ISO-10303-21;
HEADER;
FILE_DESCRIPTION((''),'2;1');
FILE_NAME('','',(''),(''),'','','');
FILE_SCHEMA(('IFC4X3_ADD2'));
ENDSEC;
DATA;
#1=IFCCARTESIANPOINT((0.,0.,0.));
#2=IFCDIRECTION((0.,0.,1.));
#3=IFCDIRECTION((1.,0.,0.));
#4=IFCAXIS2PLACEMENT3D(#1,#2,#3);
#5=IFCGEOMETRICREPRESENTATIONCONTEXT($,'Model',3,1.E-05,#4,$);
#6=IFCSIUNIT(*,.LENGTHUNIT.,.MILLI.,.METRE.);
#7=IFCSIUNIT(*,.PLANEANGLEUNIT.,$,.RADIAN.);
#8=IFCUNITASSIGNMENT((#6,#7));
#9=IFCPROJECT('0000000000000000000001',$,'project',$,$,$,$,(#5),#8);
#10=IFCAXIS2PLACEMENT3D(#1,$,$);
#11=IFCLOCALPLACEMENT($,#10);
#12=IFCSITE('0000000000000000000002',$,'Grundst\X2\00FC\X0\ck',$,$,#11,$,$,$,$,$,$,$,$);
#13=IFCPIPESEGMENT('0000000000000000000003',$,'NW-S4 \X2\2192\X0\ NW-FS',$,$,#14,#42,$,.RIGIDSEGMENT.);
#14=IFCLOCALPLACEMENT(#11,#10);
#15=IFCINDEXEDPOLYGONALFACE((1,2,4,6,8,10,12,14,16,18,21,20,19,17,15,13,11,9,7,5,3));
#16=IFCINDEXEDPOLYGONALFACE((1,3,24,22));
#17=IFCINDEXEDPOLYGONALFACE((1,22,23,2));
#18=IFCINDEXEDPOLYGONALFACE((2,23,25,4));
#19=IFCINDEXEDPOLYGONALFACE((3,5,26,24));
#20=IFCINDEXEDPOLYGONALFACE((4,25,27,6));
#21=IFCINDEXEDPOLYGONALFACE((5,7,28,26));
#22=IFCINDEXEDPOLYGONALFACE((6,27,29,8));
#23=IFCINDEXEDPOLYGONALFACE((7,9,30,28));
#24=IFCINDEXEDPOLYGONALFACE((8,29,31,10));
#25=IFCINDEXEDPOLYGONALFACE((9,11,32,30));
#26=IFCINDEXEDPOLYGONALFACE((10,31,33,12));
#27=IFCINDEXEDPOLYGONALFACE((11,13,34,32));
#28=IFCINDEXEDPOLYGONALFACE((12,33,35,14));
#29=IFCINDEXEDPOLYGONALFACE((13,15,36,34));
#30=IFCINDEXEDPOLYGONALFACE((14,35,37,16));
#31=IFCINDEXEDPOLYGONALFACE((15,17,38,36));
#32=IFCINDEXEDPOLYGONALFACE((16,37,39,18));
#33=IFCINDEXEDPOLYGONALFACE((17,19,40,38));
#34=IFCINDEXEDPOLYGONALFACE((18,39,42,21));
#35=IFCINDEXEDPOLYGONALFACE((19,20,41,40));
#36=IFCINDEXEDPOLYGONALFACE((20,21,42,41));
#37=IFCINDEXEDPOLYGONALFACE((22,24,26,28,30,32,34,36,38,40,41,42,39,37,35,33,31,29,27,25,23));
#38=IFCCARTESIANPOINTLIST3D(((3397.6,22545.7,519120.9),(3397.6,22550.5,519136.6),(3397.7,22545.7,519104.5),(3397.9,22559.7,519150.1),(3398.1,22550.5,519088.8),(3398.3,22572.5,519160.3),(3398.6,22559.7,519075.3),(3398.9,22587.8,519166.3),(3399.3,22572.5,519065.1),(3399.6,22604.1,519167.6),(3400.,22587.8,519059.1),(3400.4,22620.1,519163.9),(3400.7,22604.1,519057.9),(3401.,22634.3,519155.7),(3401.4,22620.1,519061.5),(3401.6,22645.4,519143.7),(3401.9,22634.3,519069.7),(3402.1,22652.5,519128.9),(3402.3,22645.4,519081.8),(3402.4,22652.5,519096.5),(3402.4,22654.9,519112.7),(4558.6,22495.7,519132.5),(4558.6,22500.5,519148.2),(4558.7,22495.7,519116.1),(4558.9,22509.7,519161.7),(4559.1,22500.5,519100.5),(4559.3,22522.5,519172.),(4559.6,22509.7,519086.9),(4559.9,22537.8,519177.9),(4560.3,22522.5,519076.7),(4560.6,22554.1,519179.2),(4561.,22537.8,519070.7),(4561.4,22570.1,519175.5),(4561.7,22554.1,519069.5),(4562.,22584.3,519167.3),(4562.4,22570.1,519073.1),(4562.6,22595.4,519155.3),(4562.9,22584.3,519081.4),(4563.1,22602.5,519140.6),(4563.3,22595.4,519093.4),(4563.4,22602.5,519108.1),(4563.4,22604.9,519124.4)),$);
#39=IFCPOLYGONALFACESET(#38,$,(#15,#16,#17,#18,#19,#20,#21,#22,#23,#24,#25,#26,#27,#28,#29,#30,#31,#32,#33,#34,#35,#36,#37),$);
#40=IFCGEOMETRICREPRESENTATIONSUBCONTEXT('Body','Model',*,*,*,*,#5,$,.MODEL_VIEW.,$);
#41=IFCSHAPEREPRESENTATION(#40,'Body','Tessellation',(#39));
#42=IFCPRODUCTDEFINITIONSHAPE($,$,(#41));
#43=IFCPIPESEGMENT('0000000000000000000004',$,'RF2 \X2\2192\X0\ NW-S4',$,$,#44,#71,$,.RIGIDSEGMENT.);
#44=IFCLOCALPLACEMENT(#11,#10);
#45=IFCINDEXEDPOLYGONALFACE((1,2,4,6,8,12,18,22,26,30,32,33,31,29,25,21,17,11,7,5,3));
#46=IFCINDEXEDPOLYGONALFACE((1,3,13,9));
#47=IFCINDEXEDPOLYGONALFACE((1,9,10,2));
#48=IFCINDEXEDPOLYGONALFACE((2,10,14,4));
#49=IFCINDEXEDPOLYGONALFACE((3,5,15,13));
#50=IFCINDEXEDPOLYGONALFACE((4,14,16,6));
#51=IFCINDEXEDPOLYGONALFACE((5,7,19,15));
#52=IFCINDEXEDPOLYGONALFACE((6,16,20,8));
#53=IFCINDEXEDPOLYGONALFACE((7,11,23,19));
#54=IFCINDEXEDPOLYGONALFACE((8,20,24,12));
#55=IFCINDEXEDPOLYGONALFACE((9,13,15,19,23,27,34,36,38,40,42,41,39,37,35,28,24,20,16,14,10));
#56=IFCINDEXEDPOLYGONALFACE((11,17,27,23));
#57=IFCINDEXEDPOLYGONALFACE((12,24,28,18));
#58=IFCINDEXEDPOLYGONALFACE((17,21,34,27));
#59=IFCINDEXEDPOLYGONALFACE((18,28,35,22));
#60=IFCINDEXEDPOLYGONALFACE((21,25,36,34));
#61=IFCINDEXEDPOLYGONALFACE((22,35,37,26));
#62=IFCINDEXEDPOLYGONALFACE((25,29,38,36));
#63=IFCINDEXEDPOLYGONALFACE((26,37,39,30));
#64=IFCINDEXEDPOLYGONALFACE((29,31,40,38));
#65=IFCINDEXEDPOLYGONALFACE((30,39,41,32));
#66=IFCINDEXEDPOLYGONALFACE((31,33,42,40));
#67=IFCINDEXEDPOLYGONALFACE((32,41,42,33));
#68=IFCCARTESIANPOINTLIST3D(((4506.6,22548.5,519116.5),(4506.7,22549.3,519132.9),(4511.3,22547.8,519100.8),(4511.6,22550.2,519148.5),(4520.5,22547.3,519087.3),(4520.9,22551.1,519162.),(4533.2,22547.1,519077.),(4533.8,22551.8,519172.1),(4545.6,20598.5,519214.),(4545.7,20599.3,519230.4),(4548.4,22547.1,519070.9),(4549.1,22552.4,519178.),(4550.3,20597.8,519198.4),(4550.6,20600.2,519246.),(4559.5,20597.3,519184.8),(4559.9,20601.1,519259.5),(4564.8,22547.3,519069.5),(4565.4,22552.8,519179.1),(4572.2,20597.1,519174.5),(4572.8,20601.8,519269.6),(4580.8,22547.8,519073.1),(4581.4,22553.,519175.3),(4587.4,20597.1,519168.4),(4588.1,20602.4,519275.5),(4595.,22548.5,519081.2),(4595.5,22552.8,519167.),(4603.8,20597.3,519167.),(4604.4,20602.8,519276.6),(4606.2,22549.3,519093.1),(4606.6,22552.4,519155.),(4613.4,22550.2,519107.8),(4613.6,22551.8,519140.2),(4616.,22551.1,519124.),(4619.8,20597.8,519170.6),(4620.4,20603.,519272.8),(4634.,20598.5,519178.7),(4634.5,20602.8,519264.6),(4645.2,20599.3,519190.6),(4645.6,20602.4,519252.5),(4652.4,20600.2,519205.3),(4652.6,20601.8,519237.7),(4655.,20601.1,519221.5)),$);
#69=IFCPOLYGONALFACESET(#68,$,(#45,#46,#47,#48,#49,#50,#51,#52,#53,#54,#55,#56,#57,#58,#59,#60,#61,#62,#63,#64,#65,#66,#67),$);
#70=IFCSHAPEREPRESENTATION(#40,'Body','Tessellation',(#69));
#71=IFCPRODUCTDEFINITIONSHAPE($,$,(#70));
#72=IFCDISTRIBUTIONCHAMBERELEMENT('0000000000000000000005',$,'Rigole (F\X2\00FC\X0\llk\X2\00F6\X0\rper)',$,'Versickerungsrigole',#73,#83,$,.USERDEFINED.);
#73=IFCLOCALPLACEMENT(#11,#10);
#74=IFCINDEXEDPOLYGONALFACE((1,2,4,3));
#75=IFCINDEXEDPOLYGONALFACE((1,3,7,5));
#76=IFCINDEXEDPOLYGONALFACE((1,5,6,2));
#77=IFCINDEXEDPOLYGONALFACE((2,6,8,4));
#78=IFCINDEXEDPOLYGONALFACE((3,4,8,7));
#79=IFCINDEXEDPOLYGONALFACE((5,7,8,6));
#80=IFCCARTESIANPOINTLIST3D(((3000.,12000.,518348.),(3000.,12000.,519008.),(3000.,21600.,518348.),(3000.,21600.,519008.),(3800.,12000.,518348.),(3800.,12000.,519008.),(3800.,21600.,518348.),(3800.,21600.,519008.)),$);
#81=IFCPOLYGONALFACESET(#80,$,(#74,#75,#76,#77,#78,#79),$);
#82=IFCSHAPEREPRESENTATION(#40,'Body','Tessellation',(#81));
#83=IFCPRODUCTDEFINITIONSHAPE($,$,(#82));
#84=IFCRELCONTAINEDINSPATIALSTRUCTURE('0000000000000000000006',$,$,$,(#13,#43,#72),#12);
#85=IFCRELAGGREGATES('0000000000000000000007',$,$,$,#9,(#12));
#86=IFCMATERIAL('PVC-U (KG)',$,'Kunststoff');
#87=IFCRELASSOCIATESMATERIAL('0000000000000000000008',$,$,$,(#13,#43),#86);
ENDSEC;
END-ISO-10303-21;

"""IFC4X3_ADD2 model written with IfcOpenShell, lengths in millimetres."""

from ifc_helpers import new_model, si_unit, frame, frame_2d, origin, origin_with_axes, place, context, subcontext, project, spatial, rectangle, circle, extrude, material, element, save


model = new_model("IFC4X3_ADD2")

# Units and contexts
model_context = context("Model", 3, precision=1e-05, world=origin_with_axes())
body_context = subcontext(model_context, "Body", "Model", "MODEL_VIEW")
ifc_project = project(units=[si_unit("LENGTHUNIT", "METRE", prefix="MILLI"), si_unit("PLANEANGLEUNIT", "RADIAN")], contexts=[model_context])

# Site
site_placement = place(None, origin())
site = spatial("IfcSite", under=ifc_project, at=site_placement, Name="Grundstück")

# Shared definitions
ifc_material = material(Name="PVC-U (KG)", Category="Kunststoff")

# Pipe segments
pipe_segment_1_placement = place(site_placement, frame((4561.0, 22550.0, 519069.3)))
element("IfcPipeSegment", 1, at=pipe_segment_1_placement, inside=site, material=ifc_material, Name="NW-S4 → NW-FS", PredefinedType="RIGIDSEGMENT", context=body_context, shape_type="SweptSolid", body=[
    extrude(circle(Radius=55.0), frame((0.0, 0.0, 55.0), z_axis=(-0.999024, 0.043024, -0.01), x_axis=(0.0, 1.0, 0.0)), (0.0, 0.0, 1.0), 1162.1),
])
pipe_segment_2_placement = place(site_placement, frame((4600.0, 20600.0, 519166.9)))
element("IfcPipeSegment", 2, at=pipe_segment_2_placement, inside=site, material=ifc_material, Name="RF2 → NW-S4", PredefinedType="RIGIDSEGMENT", context=body_context, shape_type="SweptSolid", body=[
    extrude(circle(Radius=55.0), frame((0.0, 0.0, 55.0), z_axis=(-0.019971, 0.998553, -0.049938), x_axis=(0.0, 1.0, 0.0)), (0.0, 0.0, 1.0), 1952.8),
])

# Distribution chamber element
distribution_chamber_element_1_placement = place(site_placement, frame((3000.0, 12000.0, 518348.0)))
element("IfcDistributionChamberElement", 3, at=distribution_chamber_element_1_placement, inside=site, Name="Rigole (Füllkörper)", ObjectType="Versickerungsrigole", PredefinedType="USERDEFINED", context=body_context, shape_type="SweptSolid", body=[
    extrude(rectangle(XDim=800.0, YDim=9600.0, at=frame_2d((400.0, 4800.0))), origin(), (0.0, 0.0, 1.0), 660.0),
])

save(model, "model.ifc")
